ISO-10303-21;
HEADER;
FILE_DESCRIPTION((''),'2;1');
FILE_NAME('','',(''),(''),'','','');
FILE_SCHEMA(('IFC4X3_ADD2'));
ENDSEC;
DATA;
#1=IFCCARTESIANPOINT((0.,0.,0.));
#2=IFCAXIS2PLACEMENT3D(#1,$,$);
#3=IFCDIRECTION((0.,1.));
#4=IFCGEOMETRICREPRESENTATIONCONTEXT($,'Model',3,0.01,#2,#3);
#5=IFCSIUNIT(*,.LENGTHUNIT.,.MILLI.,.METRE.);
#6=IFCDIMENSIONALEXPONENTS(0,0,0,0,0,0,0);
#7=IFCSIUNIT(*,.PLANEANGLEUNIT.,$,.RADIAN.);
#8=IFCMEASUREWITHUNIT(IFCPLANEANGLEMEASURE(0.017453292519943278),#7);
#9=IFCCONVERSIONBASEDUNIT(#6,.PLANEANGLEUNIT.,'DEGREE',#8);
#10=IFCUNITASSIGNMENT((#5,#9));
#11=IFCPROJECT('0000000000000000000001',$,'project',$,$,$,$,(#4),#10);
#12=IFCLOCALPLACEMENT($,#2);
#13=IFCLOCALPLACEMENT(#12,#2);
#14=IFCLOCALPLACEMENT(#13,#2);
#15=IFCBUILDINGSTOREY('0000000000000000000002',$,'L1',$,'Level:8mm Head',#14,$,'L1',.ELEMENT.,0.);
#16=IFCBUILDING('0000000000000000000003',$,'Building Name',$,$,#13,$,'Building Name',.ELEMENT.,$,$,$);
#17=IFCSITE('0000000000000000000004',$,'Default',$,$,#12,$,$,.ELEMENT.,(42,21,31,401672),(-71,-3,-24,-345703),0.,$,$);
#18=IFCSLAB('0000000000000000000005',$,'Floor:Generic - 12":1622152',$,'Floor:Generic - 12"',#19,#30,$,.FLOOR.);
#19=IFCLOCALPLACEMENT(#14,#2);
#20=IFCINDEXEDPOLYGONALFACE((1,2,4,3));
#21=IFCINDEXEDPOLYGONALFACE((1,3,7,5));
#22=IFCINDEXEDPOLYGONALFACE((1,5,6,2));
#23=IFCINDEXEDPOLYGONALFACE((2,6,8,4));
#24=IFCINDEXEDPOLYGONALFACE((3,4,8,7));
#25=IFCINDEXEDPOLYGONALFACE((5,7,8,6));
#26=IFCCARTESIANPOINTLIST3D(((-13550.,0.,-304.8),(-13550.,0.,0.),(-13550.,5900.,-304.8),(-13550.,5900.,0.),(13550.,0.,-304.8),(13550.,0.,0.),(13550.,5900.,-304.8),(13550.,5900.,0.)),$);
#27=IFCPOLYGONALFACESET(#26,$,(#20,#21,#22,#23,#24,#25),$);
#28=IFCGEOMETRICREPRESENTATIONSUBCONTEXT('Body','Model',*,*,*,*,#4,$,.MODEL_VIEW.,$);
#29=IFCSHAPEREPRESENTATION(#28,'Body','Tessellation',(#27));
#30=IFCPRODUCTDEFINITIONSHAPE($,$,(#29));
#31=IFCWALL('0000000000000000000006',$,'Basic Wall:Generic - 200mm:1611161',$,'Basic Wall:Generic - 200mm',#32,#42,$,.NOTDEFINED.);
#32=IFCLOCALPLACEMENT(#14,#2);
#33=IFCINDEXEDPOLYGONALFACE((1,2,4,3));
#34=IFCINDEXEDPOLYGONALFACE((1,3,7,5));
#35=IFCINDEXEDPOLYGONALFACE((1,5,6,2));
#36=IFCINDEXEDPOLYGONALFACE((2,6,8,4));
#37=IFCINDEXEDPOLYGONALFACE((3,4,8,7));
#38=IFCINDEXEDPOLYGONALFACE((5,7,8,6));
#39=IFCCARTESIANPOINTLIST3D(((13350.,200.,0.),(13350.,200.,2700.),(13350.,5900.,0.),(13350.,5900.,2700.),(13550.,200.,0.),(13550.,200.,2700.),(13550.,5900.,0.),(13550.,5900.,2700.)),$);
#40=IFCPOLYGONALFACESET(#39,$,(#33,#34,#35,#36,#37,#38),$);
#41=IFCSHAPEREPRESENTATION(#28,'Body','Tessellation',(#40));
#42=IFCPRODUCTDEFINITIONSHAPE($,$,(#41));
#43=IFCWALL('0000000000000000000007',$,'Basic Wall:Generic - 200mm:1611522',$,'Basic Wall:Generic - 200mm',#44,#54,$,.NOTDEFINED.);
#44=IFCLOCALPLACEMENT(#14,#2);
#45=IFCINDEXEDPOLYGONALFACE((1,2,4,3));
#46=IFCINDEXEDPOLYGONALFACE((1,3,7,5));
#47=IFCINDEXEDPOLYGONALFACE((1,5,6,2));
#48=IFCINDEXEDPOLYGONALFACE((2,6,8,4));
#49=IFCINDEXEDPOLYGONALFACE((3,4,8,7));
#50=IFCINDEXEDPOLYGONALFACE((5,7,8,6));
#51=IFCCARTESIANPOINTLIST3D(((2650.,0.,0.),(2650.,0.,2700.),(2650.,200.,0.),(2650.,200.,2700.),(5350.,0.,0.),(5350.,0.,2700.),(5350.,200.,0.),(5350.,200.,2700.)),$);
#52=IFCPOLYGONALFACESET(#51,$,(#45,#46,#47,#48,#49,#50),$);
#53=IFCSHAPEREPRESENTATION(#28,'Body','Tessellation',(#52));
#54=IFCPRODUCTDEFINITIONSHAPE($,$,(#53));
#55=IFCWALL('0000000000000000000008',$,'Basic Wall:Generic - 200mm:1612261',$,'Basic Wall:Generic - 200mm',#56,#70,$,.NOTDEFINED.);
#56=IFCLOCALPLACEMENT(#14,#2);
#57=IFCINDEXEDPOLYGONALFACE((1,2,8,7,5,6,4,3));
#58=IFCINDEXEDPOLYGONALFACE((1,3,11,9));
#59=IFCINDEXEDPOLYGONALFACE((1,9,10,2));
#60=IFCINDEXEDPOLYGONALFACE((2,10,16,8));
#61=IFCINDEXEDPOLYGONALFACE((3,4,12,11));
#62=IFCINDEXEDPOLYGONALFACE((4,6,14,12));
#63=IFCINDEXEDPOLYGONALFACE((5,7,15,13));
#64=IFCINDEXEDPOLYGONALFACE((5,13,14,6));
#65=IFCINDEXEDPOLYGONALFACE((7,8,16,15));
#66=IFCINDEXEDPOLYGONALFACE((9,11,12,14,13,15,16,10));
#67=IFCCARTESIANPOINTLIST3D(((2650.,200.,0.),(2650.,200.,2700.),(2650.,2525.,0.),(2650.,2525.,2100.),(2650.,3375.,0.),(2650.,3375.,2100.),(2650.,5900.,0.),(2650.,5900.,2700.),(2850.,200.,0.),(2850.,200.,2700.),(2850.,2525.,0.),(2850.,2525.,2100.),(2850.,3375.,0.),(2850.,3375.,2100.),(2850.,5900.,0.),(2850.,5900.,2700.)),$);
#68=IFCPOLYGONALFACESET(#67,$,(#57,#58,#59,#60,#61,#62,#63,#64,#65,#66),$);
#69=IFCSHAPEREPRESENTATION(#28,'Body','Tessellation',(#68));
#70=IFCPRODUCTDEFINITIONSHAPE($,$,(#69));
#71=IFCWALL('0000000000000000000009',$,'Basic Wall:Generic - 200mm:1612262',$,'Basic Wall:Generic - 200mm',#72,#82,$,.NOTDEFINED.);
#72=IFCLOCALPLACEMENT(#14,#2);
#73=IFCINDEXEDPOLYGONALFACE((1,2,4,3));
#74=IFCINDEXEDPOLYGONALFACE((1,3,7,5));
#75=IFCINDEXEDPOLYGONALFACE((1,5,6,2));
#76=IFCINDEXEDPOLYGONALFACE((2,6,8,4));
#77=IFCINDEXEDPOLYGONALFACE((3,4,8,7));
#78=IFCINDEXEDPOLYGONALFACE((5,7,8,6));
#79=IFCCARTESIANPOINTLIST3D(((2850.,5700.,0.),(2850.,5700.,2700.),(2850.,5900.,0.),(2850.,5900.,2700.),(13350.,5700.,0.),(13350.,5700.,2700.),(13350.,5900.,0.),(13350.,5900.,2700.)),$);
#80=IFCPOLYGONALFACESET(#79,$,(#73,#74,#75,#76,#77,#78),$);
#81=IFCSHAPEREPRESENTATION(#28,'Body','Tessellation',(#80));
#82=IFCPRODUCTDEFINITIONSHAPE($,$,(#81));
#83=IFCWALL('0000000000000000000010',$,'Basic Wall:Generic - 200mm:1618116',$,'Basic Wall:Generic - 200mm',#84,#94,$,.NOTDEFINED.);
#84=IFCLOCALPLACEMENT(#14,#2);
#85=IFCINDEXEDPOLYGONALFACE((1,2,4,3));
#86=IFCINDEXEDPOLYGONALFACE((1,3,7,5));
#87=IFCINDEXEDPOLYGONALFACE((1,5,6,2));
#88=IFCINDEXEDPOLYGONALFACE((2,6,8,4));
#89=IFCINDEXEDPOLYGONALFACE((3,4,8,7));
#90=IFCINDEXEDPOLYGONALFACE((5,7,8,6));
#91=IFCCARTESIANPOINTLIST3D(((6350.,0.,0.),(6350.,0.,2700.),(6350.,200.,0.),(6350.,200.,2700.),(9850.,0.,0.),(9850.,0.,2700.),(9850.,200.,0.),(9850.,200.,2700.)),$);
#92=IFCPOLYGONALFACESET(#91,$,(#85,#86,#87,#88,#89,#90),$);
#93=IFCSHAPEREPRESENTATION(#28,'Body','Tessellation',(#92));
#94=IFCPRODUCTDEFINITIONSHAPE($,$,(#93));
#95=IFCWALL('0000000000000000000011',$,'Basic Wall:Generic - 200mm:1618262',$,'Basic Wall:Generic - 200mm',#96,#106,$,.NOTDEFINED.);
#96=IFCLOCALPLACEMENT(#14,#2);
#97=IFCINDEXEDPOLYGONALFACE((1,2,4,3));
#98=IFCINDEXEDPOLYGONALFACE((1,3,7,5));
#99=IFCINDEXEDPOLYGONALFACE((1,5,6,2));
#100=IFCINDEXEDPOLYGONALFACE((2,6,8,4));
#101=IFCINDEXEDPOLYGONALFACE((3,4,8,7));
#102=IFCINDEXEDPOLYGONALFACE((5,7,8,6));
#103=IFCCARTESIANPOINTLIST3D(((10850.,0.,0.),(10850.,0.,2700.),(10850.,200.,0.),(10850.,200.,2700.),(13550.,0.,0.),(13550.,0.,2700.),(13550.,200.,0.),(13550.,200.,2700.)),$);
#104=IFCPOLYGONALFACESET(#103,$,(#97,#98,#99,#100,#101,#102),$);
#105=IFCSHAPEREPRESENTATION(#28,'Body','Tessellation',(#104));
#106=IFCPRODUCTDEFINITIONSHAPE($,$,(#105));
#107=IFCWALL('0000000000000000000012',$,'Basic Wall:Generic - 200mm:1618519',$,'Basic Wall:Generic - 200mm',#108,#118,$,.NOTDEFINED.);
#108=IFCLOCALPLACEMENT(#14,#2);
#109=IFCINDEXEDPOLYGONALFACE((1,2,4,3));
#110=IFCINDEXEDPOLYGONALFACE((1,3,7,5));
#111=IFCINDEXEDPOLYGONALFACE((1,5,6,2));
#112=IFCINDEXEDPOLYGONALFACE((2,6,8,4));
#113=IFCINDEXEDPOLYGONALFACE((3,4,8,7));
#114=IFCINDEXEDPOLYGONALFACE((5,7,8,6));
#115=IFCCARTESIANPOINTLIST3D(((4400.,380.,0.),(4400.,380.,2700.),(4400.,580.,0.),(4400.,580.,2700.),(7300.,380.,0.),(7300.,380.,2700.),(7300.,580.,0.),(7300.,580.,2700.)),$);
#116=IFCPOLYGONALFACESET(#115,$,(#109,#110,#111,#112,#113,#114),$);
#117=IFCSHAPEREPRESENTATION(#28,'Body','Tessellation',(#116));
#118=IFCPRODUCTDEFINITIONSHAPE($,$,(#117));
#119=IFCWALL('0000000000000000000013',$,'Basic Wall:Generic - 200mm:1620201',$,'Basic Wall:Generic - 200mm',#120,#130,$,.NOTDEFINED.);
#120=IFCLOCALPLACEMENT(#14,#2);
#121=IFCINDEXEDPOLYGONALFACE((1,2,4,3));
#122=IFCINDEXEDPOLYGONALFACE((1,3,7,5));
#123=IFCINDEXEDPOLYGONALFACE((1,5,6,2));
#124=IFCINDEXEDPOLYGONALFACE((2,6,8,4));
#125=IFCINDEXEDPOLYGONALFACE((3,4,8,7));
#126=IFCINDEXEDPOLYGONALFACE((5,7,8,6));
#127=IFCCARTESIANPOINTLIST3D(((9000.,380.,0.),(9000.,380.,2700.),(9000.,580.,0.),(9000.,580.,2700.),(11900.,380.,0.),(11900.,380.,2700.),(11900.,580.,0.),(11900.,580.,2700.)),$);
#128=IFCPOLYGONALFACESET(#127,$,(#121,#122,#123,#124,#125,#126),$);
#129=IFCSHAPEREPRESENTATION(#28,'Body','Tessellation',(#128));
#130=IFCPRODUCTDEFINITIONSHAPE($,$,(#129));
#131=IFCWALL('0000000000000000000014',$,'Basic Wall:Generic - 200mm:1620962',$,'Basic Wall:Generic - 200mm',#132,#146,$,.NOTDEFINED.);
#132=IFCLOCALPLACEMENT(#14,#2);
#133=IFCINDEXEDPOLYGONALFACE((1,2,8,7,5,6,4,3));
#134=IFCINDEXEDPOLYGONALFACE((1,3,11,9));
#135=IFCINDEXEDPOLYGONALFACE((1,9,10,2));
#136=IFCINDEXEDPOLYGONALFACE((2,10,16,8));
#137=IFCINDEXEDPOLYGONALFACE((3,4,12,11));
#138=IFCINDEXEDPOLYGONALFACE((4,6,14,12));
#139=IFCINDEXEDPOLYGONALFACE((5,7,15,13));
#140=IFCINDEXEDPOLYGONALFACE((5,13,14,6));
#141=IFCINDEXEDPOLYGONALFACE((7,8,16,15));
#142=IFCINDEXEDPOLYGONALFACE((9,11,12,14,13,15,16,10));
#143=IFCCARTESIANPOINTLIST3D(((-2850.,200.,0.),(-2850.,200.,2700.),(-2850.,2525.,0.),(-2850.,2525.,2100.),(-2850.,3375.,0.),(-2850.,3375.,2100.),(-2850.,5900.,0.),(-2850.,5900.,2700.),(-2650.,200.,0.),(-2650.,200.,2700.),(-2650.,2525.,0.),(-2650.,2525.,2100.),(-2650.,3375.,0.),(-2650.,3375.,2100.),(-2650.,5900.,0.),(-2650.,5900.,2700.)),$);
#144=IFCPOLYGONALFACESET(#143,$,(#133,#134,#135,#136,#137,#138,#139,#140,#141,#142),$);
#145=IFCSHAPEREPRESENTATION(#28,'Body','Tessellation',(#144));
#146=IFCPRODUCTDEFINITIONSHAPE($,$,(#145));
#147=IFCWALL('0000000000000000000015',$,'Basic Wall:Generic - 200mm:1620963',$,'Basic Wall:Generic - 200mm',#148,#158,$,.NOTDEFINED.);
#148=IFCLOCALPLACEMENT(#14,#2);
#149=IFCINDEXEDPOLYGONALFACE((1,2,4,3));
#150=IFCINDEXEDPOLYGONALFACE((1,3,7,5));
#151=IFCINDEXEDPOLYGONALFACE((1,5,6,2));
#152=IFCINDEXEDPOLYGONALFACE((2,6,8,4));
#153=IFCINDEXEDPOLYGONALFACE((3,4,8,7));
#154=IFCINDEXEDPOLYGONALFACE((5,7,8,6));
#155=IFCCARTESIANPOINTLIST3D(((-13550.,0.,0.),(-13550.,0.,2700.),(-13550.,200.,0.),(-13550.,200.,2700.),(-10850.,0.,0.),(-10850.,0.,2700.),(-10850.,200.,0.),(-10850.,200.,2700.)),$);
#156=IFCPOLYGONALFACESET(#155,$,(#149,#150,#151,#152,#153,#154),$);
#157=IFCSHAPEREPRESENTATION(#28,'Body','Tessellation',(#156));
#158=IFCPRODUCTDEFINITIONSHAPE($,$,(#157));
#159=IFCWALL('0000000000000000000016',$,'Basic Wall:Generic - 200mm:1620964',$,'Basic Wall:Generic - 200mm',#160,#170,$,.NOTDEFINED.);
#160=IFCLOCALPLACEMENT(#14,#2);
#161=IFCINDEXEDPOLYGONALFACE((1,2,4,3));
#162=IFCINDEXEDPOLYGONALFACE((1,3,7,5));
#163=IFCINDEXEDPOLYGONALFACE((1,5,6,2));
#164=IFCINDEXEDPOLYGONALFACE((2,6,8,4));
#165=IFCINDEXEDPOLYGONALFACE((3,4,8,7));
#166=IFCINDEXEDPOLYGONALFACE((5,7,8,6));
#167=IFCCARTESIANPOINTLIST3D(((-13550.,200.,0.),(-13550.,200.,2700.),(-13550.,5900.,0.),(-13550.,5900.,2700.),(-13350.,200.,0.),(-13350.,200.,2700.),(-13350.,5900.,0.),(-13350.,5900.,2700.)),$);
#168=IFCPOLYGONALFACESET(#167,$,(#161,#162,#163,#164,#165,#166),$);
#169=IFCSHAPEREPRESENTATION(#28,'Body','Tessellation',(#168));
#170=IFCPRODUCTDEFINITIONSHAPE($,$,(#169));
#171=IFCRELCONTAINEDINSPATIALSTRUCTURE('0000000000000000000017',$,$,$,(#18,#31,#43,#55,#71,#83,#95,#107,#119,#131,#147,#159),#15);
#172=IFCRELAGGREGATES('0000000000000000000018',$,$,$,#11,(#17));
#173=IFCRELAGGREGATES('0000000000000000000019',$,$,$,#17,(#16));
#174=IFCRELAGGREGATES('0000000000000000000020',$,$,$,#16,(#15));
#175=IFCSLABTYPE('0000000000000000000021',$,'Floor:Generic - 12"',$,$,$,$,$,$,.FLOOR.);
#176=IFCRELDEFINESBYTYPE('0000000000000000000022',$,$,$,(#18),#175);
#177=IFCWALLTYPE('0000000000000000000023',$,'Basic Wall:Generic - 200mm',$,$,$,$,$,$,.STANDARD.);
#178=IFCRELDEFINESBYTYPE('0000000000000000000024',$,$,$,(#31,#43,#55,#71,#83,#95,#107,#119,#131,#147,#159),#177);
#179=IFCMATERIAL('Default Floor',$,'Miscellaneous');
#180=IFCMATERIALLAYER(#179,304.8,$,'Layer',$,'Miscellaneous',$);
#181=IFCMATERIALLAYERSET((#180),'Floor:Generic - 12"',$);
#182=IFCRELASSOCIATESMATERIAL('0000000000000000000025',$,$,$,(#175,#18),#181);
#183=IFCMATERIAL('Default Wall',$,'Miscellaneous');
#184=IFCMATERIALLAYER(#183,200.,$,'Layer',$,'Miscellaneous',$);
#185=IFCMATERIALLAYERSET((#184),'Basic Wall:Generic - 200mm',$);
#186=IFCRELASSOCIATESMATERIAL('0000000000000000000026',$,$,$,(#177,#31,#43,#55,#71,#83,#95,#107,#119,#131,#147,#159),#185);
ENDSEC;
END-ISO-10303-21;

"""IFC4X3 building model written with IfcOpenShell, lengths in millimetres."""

from ifc_helpers import new_model, entity, si_unit, converted_unit, direction, frame, frame_2d, origin, origin_2d_with_axis, place, context, subcontext, project, spatial, rectangle, extrude, material, layer, layer_set, layer_usage, type_object, element, save


model = new_model("IFC4X3")

# Units and contexts
model_context = context("Model", 3, precision=0.01, world=origin(), true_north=direction((0.0, 1.0)))
body_context = subcontext(model_context, "Body", "Model", "MODEL_VIEW")
ifc_project = project(units=[si_unit("LENGTHUNIT", "METRE", prefix="MILLI"), converted_unit("PLANEANGLEUNIT", "DEGREE", entity("IfcPlaneAngleMeasure", 0.017453292519943278), si_unit("PLANEANGLEUNIT", "RADIAN"), dimensions=[0, 0, 0, 0, 0, 0, 0])], contexts=[model_context])

# Site, building, storey
site_placement = place(None, origin())
site = spatial("IfcSite", under=ifc_project, at=site_placement, Name="Default", CompositionType="ELEMENT", RefLatitude=(42, 21, 31, 401672), RefLongitude=(-71, -3, -24, -345703), RefElevation=0.0)
building_placement = place(site_placement, origin())
building = spatial("IfcBuilding", under=site, at=building_placement, Name="Building Name", LongName="Building Name", CompositionType="ELEMENT")
storey_placement = place(building_placement, origin())
storey = spatial("IfcBuildingStorey", under=building, at=storey_placement, Name="L1", ObjectType="Level:8mm Head", LongName="L1", CompositionType="ELEMENT", Elevation=0.0)

# Slab
ifc_material_1 = material(Name="Default Floor", Category="Miscellaneous")
ifc_layer_1 = layer(ifc_material_1, 304.8, Name="Layer", Category="Miscellaneous")
ifc_layer_set_1 = layer_set([ifc_layer_1], Name="Floor:Generic - 12\"")
ifc_layer_usage = layer_usage(ifc_layer_set_1, "AXIS3", "POSITIVE", 0.0)
slab_type = type_object("IfcSlabType", Name="Floor:Generic - 12\"", PredefinedType="FLOOR", material=ifc_layer_set_1)
slab_placement = place(storey_placement, origin())
element("IfcSlab", 1, at=slab_placement, inside=storey, type_object=slab_type, material=ifc_layer_usage, Name="Floor:Generic - 12\":1622152", ObjectType="Floor:Generic - 12\"", PredefinedType="FLOOR", context=body_context, shape_type="SweptSolid", body=[
    extrude(rectangle(XDim=5900.0, YDim=27100.0, at=origin_2d_with_axis()), frame((0.0, 2950.0, 0.0), z_axis=(0.0, 0.0, -1.0), x_axis=(0.0, 1.0, 0.0)), (0.0, 0.0, 1.0), 304.8),
])

# Walls
ifc_material_2 = material(Name="Default Wall", Category="Miscellaneous")
ifc_layer_2 = layer(ifc_material_2, 200.0, Name="Layer", Category="Miscellaneous")
ifc_layer_set_2 = layer_set([ifc_layer_2], Name="Basic Wall:Generic - 200mm")
wall_type = type_object("IfcWallType", Name="Basic Wall:Generic - 200mm", PredefinedType="STANDARD", material=ifc_layer_set_2)
wall_1_placement = place(storey_placement, frame((13450.0, 200.0, 0.0), z_axis=(0.0, 0.0, 1.0), x_axis=(0.0, 1.0, 0.0)))
element("IfcWall", 2, at=wall_1_placement, inside=storey, type_object=wall_type, material=ifc_layer_set_2, Name="Basic Wall:Generic - 200mm:1611161", ObjectType="Basic Wall:Generic - 200mm", PredefinedType="NOTDEFINED", context=body_context, shape_type="SweptSolid", body=[
    extrude(rectangle(XDim=5700.0, YDim=200.0, at=frame_2d((2850.0, 0.0), x_axis=(-1.0, 0.0))), origin(), (0.0, 0.0, 1.0), 2700.0),
])
wall_2_placement = place(storey_placement, frame((2650.0, 100.0, 0.0)))
element("IfcWall", 3, at=wall_2_placement, inside=storey, type_object=wall_type, material=ifc_layer_set_2, Name="Basic Wall:Generic - 200mm:1611522", ObjectType="Basic Wall:Generic - 200mm", PredefinedType="NOTDEFINED", context=body_context, shape_type="SweptSolid", body=[
    extrude(rectangle(XDim=2700.0, YDim=200.0, at=frame_2d((1350.0, 0.0), x_axis=(-1.0, 0.0))), origin(), (0.0, 0.0, 1.0), 2700.0),
])

# Wall, opening
wall_3_placement = place(storey_placement, frame((2750.0, 5900.0, 0.0), z_axis=(0.0, 0.0, 1.0), x_axis=(0.0, -1.0, 0.0)))
wall_3 = element("IfcWall", 4, at=wall_3_placement, inside=storey, type_object=wall_type, material=ifc_layer_set_2, Name="Basic Wall:Generic - 200mm:1612261", ObjectType="Basic Wall:Generic - 200mm", PredefinedType="NOTDEFINED", context=body_context, shape_type="SweptSolid", body=[
    extrude(rectangle(XDim=5700.0, YDim=200.0, at=frame_2d((2850.0, 0.0), x_axis=(-1.0, 0.0))), origin(), (0.0, 0.0, 1.0), 2700.0),
])
opening_1_placement = place(wall_3_placement, frame((2525.0, -100.0, 0.0)))
element("IfcOpeningElement", 5, at=opening_1_placement, cuts=wall_3, PredefinedType="OPENING", context=body_context, shape_type="SweptSolid", body=[
    extrude(rectangle(XDim=2100.0, YDim=850.0, at=frame_2d((1050.0, 425.0), x_axis=(1.0, 0.0))), frame((0.0, 0.0, 0.0), z_axis=(0.0, 1.0, 0.0), x_axis=(0.0, 0.0, 1.0)), (0.0, 0.0, 1.0), 200.0),
])

# Walls
wall_4_placement = place(storey_placement, frame((13350.0, 5800.0, 0.0), z_axis=(0.0, 0.0, 1.0), x_axis=(-1.0, 0.0, 0.0)))
element("IfcWall", 6, at=wall_4_placement, inside=storey, type_object=wall_type, material=ifc_layer_set_2, Name="Basic Wall:Generic - 200mm:1612262", ObjectType="Basic Wall:Generic - 200mm", PredefinedType="NOTDEFINED", context=body_context, shape_type="SweptSolid", body=[
    extrude(rectangle(XDim=10500.0, YDim=200.0, at=frame_2d((5250.0, 0.0), x_axis=(-1.0, 0.0))), origin(), (0.0, 0.0, 1.0), 2700.0),
])
wall_5_placement = place(storey_placement, frame((6350.0, 100.0, 0.0)))
element("IfcWall", 7, at=wall_5_placement, inside=storey, type_object=wall_type, material=ifc_layer_set_2, Name="Basic Wall:Generic - 200mm:1618116", ObjectType="Basic Wall:Generic - 200mm", PredefinedType="NOTDEFINED", context=body_context, shape_type="SweptSolid", body=[
    extrude(rectangle(XDim=3500.0, YDim=200.0, at=frame_2d((1750.0, 0.0), x_axis=(-1.0, 0.0))), origin(), (0.0, 0.0, 1.0), 2700.0),
])
wall_6_placement = place(storey_placement, frame((10850.0, 100.0, 0.0)))
element("IfcWall", 8, at=wall_6_placement, inside=storey, type_object=wall_type, material=ifc_layer_set_2, Name="Basic Wall:Generic - 200mm:1618262", ObjectType="Basic Wall:Generic - 200mm", PredefinedType="NOTDEFINED", context=body_context, shape_type="SweptSolid", body=[
    extrude(rectangle(XDim=2700.0, YDim=200.0, at=frame_2d((1350.0, 0.0), x_axis=(-1.0, 0.0))), origin(), (0.0, 0.0, 1.0), 2700.0),
])
wall_7_placement = place(storey_placement, frame((7300.0, 480.0, 0.0), z_axis=(0.0, 0.0, 1.0), x_axis=(-1.0, 0.0, 0.0)))
element("IfcWall", 9, at=wall_7_placement, inside=storey, type_object=wall_type, material=ifc_layer_set_2, Name="Basic Wall:Generic - 200mm:1618519", ObjectType="Basic Wall:Generic - 200mm", PredefinedType="NOTDEFINED", context=body_context, shape_type="SweptSolid", body=[
    extrude(rectangle(XDim=2900.0, YDim=200.0, at=frame_2d((1450.0, 0.0), x_axis=(-1.0, 0.0))), origin(), (0.0, 0.0, 1.0), 2700.0),
])
wall_8_placement = place(storey_placement, frame((11900.0, 480.0, 0.0), z_axis=(0.0, 0.0, 1.0), x_axis=(-1.0, 0.0, 0.0)))
element("IfcWall", 10, at=wall_8_placement, inside=storey, type_object=wall_type, material=ifc_layer_set_2, Name="Basic Wall:Generic - 200mm:1620201", ObjectType="Basic Wall:Generic - 200mm", PredefinedType="NOTDEFINED", context=body_context, shape_type="SweptSolid", body=[
    extrude(rectangle(XDim=2900.0, YDim=200.0, at=frame_2d((1450.0, 0.0), x_axis=(-1.0, 0.0))), origin(), (0.0, 0.0, 1.0), 2700.0),
])

# Wall, opening
wall_9_placement = place(storey_placement, frame((-2750.0, 200.0, 0.0), z_axis=(0.0, 0.0, 1.0), x_axis=(0.0, 1.0, 0.0)))
wall_9 = element("IfcWall", 11, at=wall_9_placement, inside=storey, type_object=wall_type, material=ifc_layer_set_2, Name="Basic Wall:Generic - 200mm:1620962", ObjectType="Basic Wall:Generic - 200mm", PredefinedType="NOTDEFINED", context=body_context, shape_type="SweptSolid", body=[
    extrude(rectangle(XDim=5700.0, YDim=200.0, at=frame_2d((2850.0, 0.0), x_axis=(-1.0, 0.0))), origin(), (0.0, 0.0, 1.0), 2700.0),
])
opening_2_placement = place(wall_9_placement, frame((2325.0, -100.0, 0.0)))
element("IfcOpeningElement", 12, at=opening_2_placement, cuts=wall_9, PredefinedType="OPENING", context=body_context, shape_type="SweptSolid", body=[
    extrude(rectangle(XDim=2100.0, YDim=850.0, at=frame_2d((1050.0, 425.0), x_axis=(1.0, 0.0))), frame((0.0, 0.0, 0.0), z_axis=(0.0, 1.0, 0.0), x_axis=(0.0, 0.0, 1.0)), (0.0, 0.0, 1.0), 200.0),
])

# Walls
wall_10_placement = place(storey_placement, frame((-13550.0, 100.0, 0.0)))
element("IfcWall", 13, at=wall_10_placement, inside=storey, type_object=wall_type, material=ifc_layer_set_2, Name="Basic Wall:Generic - 200mm:1620963", ObjectType="Basic Wall:Generic - 200mm", PredefinedType="NOTDEFINED", context=body_context, shape_type="SweptSolid", body=[
    extrude(rectangle(XDim=2700.0, YDim=200.0, at=frame_2d((1350.0, 0.0), x_axis=(-1.0, 0.0))), origin(), (0.0, 0.0, 1.0), 2700.0),
])
wall_11_placement = place(storey_placement, frame((-13450.0, 5900.0, 0.0), z_axis=(0.0, 0.0, 1.0), x_axis=(0.0, -1.0, 0.0)))
element("IfcWall", 14, at=wall_11_placement, inside=storey, type_object=wall_type, material=ifc_layer_set_2, Name="Basic Wall:Generic - 200mm:1620964", ObjectType="Basic Wall:Generic - 200mm", PredefinedType="NOTDEFINED", context=body_context, shape_type="SweptSolid", body=[
    extrude(rectangle(XDim=5700.0, YDim=200.0, at=frame_2d((2850.0, 0.0), x_axis=(-1.0, 0.0))), origin(), (0.0, 0.0, 1.0), 2700.0),
])

save(model, "model.ifc")
